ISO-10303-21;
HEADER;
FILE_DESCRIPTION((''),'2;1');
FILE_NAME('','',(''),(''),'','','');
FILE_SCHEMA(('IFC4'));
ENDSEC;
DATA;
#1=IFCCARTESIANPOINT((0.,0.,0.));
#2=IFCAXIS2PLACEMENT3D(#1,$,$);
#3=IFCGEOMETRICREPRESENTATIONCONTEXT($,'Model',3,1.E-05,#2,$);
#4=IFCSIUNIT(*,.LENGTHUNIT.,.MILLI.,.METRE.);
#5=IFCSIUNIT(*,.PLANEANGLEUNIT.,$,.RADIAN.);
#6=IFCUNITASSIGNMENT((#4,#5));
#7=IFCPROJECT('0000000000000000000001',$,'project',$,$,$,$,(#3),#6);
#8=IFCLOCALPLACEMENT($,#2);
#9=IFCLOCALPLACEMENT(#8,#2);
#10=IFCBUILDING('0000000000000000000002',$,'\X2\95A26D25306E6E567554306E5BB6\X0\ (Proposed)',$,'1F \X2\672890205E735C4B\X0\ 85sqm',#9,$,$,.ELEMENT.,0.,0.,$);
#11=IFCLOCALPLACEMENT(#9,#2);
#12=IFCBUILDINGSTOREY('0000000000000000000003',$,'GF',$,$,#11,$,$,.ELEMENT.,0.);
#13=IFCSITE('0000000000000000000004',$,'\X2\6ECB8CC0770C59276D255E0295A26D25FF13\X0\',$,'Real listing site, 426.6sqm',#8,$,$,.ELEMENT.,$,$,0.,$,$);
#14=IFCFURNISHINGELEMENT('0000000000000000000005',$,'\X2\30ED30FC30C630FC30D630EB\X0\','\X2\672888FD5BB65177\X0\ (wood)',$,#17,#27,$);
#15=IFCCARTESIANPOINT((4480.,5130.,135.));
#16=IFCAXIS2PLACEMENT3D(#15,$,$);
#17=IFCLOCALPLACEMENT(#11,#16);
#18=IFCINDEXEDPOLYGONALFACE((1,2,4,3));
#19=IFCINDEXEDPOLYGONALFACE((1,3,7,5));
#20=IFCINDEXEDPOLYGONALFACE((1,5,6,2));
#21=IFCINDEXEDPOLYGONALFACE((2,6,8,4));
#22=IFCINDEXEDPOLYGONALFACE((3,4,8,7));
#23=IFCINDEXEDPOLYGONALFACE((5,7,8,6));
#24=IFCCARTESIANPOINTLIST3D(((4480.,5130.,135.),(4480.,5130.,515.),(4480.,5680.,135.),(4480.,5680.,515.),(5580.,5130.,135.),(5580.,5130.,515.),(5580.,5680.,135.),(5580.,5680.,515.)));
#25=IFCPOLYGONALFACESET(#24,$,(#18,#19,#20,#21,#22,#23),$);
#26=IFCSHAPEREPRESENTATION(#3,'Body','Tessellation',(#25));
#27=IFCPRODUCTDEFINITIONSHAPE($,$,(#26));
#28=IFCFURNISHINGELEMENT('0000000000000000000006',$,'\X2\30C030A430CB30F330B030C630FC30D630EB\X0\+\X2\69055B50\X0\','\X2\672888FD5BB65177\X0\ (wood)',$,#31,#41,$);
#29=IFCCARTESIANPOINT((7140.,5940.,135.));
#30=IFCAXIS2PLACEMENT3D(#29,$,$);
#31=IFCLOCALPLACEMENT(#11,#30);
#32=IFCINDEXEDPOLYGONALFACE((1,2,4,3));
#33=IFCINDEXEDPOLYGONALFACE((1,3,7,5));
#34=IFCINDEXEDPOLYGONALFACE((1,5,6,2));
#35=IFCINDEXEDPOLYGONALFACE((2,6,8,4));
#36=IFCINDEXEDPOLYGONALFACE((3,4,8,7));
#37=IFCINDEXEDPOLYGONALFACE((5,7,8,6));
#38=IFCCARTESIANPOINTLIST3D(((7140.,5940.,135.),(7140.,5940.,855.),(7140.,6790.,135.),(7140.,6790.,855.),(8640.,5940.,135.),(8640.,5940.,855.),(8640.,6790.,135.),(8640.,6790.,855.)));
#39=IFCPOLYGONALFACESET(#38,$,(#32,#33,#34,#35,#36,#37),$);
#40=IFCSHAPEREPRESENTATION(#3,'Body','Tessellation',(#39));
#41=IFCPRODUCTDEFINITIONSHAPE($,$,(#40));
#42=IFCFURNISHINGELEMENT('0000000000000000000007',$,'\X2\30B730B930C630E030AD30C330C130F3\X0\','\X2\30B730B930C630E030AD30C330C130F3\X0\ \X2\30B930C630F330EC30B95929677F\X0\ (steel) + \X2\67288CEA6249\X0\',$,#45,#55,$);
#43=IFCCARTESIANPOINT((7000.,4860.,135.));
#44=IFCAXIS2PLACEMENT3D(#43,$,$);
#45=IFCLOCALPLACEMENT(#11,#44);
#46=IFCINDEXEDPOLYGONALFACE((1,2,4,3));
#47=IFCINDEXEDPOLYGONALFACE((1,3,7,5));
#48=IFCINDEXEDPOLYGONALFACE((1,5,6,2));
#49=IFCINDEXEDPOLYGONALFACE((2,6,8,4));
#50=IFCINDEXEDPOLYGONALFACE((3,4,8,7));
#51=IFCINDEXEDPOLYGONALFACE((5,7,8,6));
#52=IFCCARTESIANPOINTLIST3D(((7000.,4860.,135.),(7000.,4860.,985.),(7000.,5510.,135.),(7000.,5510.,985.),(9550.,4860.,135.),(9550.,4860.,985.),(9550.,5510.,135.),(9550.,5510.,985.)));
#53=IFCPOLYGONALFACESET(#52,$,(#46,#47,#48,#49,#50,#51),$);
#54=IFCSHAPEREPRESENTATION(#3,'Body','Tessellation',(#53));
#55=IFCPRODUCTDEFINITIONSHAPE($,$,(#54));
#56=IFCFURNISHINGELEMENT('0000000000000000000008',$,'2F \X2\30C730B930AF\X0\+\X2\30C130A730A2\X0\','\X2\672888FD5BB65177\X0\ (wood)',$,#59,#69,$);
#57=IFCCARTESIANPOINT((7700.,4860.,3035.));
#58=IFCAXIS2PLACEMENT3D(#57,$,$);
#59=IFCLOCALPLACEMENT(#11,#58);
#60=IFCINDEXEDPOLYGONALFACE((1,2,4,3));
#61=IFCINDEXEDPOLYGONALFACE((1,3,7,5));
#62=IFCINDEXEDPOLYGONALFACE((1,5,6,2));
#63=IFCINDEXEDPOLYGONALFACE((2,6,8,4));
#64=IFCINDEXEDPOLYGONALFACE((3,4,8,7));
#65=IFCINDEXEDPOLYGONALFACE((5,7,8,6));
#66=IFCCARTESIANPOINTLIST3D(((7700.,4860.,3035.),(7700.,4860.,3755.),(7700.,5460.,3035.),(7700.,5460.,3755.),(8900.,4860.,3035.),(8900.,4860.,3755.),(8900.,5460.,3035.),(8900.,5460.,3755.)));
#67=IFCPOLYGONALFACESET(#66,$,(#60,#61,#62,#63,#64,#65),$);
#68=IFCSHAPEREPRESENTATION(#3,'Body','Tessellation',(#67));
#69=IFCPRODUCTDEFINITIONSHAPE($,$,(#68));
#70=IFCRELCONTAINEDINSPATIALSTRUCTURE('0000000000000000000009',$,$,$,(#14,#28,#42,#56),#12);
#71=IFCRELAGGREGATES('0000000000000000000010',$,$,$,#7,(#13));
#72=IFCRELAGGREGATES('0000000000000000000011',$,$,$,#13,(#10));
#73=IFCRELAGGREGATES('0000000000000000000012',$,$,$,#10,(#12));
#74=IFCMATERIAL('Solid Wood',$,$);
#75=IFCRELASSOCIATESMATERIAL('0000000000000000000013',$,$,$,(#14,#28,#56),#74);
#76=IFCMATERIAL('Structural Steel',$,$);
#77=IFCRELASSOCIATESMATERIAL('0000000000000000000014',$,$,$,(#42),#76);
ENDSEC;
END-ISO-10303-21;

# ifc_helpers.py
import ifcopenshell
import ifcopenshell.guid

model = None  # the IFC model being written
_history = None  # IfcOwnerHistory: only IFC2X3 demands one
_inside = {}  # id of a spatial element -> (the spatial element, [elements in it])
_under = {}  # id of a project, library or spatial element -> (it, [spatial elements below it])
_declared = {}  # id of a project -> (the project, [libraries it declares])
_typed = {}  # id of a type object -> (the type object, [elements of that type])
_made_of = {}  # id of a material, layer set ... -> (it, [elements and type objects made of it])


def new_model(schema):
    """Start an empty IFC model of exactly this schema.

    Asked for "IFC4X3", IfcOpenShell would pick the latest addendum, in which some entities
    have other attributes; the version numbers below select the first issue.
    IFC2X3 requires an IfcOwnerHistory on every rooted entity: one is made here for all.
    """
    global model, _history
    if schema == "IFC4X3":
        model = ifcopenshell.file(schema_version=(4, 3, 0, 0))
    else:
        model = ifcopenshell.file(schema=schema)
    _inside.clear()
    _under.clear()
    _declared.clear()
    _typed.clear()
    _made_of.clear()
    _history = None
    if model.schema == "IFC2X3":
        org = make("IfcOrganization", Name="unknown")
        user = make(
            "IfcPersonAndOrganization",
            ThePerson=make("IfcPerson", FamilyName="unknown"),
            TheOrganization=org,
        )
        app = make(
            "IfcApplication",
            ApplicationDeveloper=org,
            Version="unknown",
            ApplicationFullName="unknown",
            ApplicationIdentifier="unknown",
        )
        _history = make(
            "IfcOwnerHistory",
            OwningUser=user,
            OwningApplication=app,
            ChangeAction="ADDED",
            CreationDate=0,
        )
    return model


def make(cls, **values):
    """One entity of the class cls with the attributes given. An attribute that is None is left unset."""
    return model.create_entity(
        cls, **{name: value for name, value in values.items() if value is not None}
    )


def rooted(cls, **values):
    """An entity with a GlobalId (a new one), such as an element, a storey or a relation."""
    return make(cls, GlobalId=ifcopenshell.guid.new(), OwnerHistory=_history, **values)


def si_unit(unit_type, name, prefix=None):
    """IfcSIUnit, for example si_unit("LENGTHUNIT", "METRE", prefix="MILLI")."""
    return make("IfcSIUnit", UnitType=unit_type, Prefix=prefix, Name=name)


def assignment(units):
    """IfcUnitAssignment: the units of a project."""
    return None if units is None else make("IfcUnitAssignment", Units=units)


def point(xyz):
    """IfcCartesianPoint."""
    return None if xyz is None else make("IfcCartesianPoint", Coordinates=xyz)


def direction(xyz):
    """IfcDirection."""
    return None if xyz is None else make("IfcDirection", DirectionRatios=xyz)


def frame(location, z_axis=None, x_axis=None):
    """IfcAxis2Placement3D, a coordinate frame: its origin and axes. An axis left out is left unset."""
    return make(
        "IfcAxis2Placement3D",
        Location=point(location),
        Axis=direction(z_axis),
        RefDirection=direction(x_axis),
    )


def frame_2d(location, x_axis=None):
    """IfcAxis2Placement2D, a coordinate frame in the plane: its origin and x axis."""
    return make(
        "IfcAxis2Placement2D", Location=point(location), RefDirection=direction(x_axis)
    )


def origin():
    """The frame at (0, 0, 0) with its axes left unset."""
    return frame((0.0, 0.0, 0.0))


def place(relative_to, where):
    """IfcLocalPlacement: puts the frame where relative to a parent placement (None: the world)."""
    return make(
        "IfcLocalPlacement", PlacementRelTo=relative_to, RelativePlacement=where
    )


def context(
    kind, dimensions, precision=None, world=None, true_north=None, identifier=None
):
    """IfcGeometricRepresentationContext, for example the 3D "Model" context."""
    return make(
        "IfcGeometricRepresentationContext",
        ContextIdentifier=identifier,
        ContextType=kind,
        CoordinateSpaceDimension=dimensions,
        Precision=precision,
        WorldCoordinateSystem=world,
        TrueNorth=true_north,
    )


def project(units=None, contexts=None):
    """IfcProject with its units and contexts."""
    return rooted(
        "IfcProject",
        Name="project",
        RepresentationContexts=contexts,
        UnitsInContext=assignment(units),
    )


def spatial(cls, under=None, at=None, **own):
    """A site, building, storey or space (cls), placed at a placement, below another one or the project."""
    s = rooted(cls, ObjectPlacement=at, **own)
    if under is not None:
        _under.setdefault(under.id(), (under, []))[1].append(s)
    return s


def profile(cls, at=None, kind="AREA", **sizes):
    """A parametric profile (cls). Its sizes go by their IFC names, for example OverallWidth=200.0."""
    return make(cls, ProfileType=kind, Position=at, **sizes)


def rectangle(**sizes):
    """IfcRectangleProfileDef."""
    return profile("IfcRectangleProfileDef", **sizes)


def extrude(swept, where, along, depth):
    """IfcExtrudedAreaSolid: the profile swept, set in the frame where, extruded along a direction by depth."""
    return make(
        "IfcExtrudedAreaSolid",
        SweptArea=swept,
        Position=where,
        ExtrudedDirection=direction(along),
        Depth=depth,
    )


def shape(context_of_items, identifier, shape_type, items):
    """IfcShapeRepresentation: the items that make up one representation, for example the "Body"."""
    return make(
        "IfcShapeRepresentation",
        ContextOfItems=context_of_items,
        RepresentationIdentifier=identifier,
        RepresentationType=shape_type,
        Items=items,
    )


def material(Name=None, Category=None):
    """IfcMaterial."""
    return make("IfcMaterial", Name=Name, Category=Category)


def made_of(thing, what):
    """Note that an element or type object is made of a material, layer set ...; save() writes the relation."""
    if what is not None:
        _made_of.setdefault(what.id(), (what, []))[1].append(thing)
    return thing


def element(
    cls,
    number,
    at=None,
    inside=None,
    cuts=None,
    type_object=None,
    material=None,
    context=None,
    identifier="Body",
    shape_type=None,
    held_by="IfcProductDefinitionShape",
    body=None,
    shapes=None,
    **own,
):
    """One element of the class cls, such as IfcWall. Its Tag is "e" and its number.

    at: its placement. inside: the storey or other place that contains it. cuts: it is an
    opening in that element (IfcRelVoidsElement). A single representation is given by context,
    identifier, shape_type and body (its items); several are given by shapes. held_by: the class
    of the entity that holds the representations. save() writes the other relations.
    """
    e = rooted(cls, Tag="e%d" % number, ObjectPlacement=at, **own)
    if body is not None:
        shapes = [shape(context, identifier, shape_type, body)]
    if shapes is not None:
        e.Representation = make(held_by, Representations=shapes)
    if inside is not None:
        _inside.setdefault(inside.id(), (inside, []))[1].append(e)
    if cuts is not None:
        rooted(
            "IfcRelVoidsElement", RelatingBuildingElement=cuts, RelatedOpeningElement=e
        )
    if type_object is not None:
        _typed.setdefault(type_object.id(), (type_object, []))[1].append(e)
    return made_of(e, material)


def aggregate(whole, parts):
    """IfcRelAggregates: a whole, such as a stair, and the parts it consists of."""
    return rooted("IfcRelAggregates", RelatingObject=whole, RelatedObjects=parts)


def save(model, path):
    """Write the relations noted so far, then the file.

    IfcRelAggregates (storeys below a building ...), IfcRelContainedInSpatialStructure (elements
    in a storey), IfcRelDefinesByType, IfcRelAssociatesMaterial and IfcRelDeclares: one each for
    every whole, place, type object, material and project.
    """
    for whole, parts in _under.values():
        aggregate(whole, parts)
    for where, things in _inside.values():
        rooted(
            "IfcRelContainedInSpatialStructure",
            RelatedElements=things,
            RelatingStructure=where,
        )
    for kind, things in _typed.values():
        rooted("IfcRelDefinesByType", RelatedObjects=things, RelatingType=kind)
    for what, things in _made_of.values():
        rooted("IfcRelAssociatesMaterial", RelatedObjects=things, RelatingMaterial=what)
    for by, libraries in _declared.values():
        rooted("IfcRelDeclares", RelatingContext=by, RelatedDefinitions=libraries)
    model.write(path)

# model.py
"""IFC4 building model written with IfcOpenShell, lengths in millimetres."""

from ifc_helpers import new_model, si_unit, frame, frame_2d, origin, place, context, project, spatial, rectangle, extrude, material, element, save


model = new_model("IFC4")

# Units and contexts
model_context = context("Model", 3, precision=1e-05, world=origin())
ifc_project = project(units=[si_unit("LENGTHUNIT", "METRE", prefix="MILLI"), si_unit("PLANEANGLEUNIT", "RADIAN")], contexts=[model_context])

# Site, building, storey
site_placement = place(None, origin())
site = spatial("IfcSite", under=ifc_project, at=site_placement, Name="滋賀県大津市関津３", ObjectType="Real listing site, 426.6sqm", CompositionType="ELEMENT", RefElevation=0.0)
building_placement = place(site_placement, origin())
building = spatial("IfcBuilding", under=site, at=building_placement, Name="関津の湖畔の家 (Proposed)", ObjectType="1F 木造平屋 85sqm", CompositionType="ELEMENT", ElevationOfRefHeight=0.0, ElevationOfTerrain=0.0)
storey_placement = place(building_placement, origin())
storey = spatial("IfcBuildingStorey", under=building, at=storey_placement, Name="GF", CompositionType="ELEMENT", Elevation=0.0)

# Shared definitions
ifc_material_1 = material(Name="Solid Wood")

# Shared definitions
ifc_material_2 = material(Name="Structural Steel")

# Furnishing elements
furnishing_1_placement = place(storey_placement, frame((4480.0, 5130.0, 135.0)))
element("IfcFurnishingElement", 1, at=furnishing_1_placement, inside=storey, material=ifc_material_1, Name="ローテーブル", Description="木製家具 (wood)", context=model_context, shape_type="SweptSolid", body=[
    extrude(rectangle(XDim=1100.0, YDim=550.0, at=frame_2d((550.0, 275.0))), frame((4480.0, 5130.0, 135.0)), (0.0, 0.0, 1.0), 380.0),
])
furnishing_2_placement = place(storey_placement, frame((7140.0, 5940.0, 135.0)))
element("IfcFurnishingElement", 2, at=furnishing_2_placement, inside=storey, material=ifc_material_1, Name="ダイニングテーブル+椅子", Description="木製家具 (wood)", context=model_context, shape_type="SweptSolid", body=[
    extrude(rectangle(XDim=1500.0, YDim=850.0, at=frame_2d((750.0, 425.0))), frame((7140.0, 5940.0, 135.0)), (0.0, 0.0, 1.0), 720.0),
])
furnishing_3_placement = place(storey_placement, frame((7000.0, 4860.0, 135.0)))
element("IfcFurnishingElement", 3, at=furnishing_3_placement, inside=storey, material=ifc_material_2, Name="システムキッチン", Description="システムキッチン ステンレス天板 (steel) + 木質扉", context=model_context, shape_type="SweptSolid", body=[
    extrude(rectangle(XDim=2550.0, YDim=650.0, at=frame_2d((1275.0, 325.0))), frame((7000.0, 4860.0, 135.0)), (0.0, 0.0, 1.0), 850.0),
])
furnishing_4_placement = place(storey_placement, frame((7700.0, 4860.0, 3035.0)))
element("IfcFurnishingElement", 4, at=furnishing_4_placement, inside=storey, material=ifc_material_1, Name="2F デスク+チェア", Description="木製家具 (wood)", context=model_context, shape_type="SweptSolid", body=[
    extrude(rectangle(XDim=1200.0, YDim=600.0, at=frame_2d((600.0, 300.0))), frame((7700.0, 4860.0, 3035.0)), (0.0, 0.0, 1.0), 720.0),
])

save(model, "model.ifc")
